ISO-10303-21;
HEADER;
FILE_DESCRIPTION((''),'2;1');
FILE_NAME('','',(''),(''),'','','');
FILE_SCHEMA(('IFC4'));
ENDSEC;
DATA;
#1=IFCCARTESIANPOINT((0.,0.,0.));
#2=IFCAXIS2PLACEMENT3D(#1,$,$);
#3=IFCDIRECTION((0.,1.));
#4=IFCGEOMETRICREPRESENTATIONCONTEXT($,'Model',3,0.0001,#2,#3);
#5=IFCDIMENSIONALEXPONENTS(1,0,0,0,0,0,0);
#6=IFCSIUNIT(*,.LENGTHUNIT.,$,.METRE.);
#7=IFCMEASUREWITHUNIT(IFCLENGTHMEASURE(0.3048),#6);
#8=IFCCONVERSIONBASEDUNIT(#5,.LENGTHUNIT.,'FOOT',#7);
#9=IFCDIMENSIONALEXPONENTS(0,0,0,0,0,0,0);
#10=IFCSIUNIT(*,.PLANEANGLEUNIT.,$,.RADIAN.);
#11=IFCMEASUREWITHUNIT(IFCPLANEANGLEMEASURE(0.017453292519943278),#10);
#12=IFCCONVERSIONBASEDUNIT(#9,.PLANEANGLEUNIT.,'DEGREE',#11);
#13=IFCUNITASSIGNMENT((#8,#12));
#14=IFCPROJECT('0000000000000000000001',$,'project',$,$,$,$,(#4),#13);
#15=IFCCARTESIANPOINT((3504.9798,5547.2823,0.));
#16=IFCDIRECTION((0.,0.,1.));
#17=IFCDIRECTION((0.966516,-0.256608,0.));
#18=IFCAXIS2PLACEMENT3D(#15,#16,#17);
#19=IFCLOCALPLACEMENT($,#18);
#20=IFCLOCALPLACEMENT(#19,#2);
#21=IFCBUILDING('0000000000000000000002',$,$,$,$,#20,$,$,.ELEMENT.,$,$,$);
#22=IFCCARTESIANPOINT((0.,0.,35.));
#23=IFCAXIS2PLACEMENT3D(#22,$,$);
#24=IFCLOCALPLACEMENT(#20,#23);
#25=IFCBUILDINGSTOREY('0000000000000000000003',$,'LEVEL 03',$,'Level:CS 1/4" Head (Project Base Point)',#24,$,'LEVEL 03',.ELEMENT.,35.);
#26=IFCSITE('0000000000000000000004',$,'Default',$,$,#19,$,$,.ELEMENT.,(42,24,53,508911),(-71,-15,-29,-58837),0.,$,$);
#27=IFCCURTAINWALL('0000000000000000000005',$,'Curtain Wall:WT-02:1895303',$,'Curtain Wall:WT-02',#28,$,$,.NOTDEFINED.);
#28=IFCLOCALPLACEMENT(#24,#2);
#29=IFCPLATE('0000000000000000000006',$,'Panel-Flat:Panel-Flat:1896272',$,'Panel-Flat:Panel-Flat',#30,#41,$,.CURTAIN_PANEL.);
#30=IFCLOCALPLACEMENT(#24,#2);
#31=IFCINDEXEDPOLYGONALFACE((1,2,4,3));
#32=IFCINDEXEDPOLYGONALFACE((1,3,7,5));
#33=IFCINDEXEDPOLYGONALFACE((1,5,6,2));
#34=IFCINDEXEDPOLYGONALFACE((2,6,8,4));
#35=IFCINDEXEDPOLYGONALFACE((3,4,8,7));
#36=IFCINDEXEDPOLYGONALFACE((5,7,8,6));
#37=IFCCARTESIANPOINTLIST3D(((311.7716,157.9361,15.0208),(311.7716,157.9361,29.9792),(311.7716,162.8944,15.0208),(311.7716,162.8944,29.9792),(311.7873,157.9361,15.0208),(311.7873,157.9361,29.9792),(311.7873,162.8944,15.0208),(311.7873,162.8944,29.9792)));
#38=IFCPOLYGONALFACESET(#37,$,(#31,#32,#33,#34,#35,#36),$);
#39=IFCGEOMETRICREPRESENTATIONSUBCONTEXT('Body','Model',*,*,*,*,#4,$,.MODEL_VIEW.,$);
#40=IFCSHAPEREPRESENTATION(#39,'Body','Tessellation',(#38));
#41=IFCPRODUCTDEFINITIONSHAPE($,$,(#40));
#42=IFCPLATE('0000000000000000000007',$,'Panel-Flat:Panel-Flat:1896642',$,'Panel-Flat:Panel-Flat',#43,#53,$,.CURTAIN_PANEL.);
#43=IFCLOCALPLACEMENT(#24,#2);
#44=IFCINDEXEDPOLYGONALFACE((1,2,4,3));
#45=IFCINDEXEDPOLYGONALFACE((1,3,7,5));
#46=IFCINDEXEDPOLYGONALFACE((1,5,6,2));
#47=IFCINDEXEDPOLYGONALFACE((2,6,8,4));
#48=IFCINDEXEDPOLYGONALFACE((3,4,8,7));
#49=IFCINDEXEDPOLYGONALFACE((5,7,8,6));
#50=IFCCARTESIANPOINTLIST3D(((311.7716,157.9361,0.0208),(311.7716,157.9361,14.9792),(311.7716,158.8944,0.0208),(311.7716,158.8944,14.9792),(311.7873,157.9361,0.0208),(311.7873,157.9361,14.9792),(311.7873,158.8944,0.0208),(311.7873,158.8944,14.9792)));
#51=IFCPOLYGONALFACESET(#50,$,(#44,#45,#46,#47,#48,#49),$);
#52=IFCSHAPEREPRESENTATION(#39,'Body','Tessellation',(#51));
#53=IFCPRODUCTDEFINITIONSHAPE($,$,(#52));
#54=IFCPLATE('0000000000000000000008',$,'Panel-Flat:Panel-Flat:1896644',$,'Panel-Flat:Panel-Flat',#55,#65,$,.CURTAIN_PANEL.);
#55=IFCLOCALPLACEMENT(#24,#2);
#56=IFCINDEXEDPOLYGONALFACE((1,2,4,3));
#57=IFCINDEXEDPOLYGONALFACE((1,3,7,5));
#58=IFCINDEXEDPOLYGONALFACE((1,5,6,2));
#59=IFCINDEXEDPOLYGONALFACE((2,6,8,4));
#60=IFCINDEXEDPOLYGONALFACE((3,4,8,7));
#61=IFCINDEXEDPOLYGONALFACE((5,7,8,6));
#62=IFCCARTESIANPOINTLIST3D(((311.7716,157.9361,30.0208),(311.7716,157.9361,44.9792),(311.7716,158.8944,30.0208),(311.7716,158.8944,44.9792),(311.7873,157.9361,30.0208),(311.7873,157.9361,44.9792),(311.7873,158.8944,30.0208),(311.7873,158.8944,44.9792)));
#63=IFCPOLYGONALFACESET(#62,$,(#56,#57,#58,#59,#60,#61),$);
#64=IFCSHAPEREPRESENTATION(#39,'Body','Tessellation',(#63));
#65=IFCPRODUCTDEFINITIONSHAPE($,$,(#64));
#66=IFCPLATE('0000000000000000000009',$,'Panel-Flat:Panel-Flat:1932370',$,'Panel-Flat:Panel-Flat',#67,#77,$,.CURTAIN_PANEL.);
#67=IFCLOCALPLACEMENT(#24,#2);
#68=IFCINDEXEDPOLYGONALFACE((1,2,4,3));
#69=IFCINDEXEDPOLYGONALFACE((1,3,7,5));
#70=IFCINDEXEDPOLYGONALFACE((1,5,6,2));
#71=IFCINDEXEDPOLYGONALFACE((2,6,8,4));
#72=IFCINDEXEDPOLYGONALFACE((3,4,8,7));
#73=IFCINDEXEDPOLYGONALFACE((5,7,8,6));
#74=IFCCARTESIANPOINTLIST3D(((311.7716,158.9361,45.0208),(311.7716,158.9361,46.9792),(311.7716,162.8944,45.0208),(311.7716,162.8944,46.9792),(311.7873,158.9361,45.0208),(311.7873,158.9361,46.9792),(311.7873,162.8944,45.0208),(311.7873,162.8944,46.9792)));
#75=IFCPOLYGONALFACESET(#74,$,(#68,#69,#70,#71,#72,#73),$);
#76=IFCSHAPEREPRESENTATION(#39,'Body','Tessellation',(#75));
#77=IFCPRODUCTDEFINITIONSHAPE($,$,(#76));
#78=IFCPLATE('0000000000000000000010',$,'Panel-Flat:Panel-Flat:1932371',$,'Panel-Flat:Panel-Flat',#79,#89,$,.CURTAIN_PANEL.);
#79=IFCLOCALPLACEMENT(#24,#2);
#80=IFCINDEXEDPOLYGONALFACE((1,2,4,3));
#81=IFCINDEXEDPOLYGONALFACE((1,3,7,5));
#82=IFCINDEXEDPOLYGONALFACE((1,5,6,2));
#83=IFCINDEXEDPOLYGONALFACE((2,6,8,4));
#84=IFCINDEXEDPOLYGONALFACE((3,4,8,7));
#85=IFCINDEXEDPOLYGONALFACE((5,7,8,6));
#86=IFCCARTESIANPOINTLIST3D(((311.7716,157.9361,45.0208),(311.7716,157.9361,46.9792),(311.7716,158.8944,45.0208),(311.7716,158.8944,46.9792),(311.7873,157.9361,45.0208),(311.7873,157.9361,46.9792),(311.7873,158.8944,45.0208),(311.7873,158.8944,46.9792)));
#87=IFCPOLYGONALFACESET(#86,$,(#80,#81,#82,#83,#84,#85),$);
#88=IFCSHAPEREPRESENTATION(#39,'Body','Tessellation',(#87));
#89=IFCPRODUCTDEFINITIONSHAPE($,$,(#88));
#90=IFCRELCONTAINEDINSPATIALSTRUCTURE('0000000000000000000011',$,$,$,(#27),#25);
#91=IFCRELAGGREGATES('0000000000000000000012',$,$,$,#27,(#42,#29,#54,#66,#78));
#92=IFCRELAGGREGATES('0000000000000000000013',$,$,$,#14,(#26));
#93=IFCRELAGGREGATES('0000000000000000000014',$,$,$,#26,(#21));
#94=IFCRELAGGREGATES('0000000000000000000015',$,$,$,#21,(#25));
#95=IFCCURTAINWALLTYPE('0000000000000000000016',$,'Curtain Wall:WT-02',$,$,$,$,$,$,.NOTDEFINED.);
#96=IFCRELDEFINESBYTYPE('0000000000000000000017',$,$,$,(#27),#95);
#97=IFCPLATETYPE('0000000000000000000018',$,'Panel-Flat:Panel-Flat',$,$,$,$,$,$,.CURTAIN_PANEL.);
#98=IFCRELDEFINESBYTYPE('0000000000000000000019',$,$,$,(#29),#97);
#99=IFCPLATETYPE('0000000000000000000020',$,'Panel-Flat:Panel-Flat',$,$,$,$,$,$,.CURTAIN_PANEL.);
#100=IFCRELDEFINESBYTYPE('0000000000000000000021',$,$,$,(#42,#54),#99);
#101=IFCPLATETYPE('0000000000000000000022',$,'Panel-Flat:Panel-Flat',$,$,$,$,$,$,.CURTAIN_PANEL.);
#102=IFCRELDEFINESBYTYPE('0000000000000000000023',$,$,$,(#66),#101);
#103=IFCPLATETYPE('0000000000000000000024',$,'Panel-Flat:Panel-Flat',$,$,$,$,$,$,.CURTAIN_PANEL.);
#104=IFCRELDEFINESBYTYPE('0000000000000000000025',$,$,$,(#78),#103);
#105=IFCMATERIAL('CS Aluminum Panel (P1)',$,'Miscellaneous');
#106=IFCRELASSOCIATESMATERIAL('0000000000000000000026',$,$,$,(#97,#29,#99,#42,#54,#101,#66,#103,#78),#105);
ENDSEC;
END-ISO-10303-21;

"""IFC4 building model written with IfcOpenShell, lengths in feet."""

from ifc_helpers import new_model, entity, si_unit, converted_unit, direction, frame, origin, place, context, subcontext, project, spatial, indexed_curve, outline, extrude, source, transform, mapped, material, type_object, type_shapes, element, aggregate, save


model = new_model("IFC4")

# Units and contexts
model_context = context("Model", 3, precision=0.0001, world=origin(), true_north=direction((0.0, 1.0)))
body_context = subcontext(model_context, "Body", "Model", "MODEL_VIEW")
ifc_project = project(units=[converted_unit("LENGTHUNIT", "FOOT", entity("IfcLengthMeasure", 0.3048), si_unit("LENGTHUNIT", "METRE"), dimensions=[1, 0, 0, 0, 0, 0, 0]), converted_unit("PLANEANGLEUNIT", "DEGREE", entity("IfcPlaneAngleMeasure", 0.017453292519943278), si_unit("PLANEANGLEUNIT", "RADIAN"), dimensions=[0, 0, 0, 0, 0, 0, 0])], contexts=[model_context])

# Site, building, storey
site_placement = place(None, frame((3504.9798, 5547.2823, 0.0), z_axis=(0.0, 0.0, 1.0), x_axis=(0.966516, -0.256608, 0.0)))
site = spatial("IfcSite", under=ifc_project, at=site_placement, Name="Default", CompositionType="ELEMENT", RefLatitude=(42, 24, 53, 508911), RefLongitude=(-71, -15, -29, -58837), RefElevation=0.0)
building_placement = place(site_placement, origin())
building = spatial("IfcBuilding", under=site, at=building_placement, CompositionType="ELEMENT")
storey_placement = place(building_placement, frame((0.0, 0.0, 35.0)))
storey = spatial("IfcBuildingStorey", under=building, at=storey_placement, Name="LEVEL 03", ObjectType="Level:CS 1/4\" Head (Project Base Point)", LongName="LEVEL 03", CompositionType="ELEMENT", Elevation=35.0)

# Curtain wall, plates
curtain_wall_type = type_object("IfcCurtainWallType", Name="Curtain Wall:WT-02", PredefinedType="NOTDEFINED")
curtain_wall_placement = place(storey_placement, frame((0.0, 0.0, -35.0)))
curtain_wall = element("IfcCurtainWall", 1, at=curtain_wall_placement, inside=storey, type_object=curtain_wall_type, Name="Curtain Wall:WT-02:1895303", ObjectType="Curtain Wall:WT-02", PredefinedType="NOTDEFINED")
ifc_material_1 = material(Name="CS Aluminum Panel (P1)", Category="Miscellaneous")
plate_type_1 = type_object("IfcPlateType", Name="Panel-Flat:Panel-Flat", PredefinedType="CURTAIN_PANEL", material=ifc_material_1)
shared_shape_1 = source(origin(), body_context, "Body", "SweptSolid", [
    extrude(outline(indexed_curve([(-0.0078, -2.4792), (0.0078, -2.4792), (0.0078, 2.4792), (-0.0078, 2.4792), (-0.0078, -2.4792)], self_intersect=False)), frame((2.4792, 0.0078, 0.0), z_axis=(0.0, 0.0, 1.0), x_axis=(0.0, -1.0, 0.0)), (0.0, 0.0, 1.0), 14.9583),
])
type_shapes(plate_type_1, [shared_shape_1])
plate_1_placement = place(curtain_wall_placement, frame((311.7716, 162.8944, 50.0208), z_axis=(0.0, 0.0, 1.0), x_axis=(0.0, -1.0, 0.0)))
plate_1 = element("IfcPlate", 2, at=plate_1_placement, type_object=plate_type_1, material=ifc_material_1, Name="Panel-Flat:Panel-Flat:1896272", ObjectType="Panel-Flat:Panel-Flat", PredefinedType="CURTAIN_PANEL", context=body_context, shape_type="MappedRepresentation", body=[
    mapped(shared_shape_1, transform((0.0, 0.0, 0.0), scale=1.0)),
])
plate_type_2 = type_object("IfcPlateType", Name="Panel-Flat:Panel-Flat", PredefinedType="CURTAIN_PANEL", material=ifc_material_1)
shared_shape_2 = source(origin(), body_context, "Body", "SweptSolid", [
    extrude(outline(indexed_curve([(-0.0078, -0.4792), (0.0078, -0.4792), (0.0078, 0.4792), (-0.0078, 0.4792), (-0.0078, -0.4792)], self_intersect=False)), frame((0.4792, 0.0078, 0.0), z_axis=(0.0, 0.0, 1.0), x_axis=(0.0, -1.0, 0.0)), (0.0, 0.0, 1.0), 14.9583),
])
type_shapes(plate_type_2, [shared_shape_2])
plate_2_placement = place(curtain_wall_placement, frame((311.7716, 158.8944, 35.0208), z_axis=(0.0, 0.0, 1.0), x_axis=(0.0, -1.0, 0.0)))
plate_2 = element("IfcPlate", 3, at=plate_2_placement, type_object=plate_type_2, material=ifc_material_1, Name="Panel-Flat:Panel-Flat:1896642", ObjectType="Panel-Flat:Panel-Flat", PredefinedType="CURTAIN_PANEL", context=body_context, shape_type="MappedRepresentation", body=[
    mapped(shared_shape_2, transform((0.0, 0.0, 0.0), scale=1.0)),
])
plate_3_placement = place(curtain_wall_placement, frame((311.7716, 158.8944, 65.0208), z_axis=(0.0, 0.0, 1.0), x_axis=(0.0, -1.0, 0.0)))
plate_3 = element("IfcPlate", 4, at=plate_3_placement, type_object=plate_type_2, material=ifc_material_1, Name="Panel-Flat:Panel-Flat:1896644", ObjectType="Panel-Flat:Panel-Flat", PredefinedType="CURTAIN_PANEL", context=body_context, shape_type="MappedRepresentation", body=[
    mapped(shared_shape_2, transform((0.0, 0.0, 0.0), scale=1.0)),
])
plate_type_3 = type_object("IfcPlateType", Name="Panel-Flat:Panel-Flat", PredefinedType="CURTAIN_PANEL", material=ifc_material_1)
shared_shape_3 = source(origin(), body_context, "Body", "SweptSolid", [
    extrude(outline(indexed_curve([(-0.0078, -1.9792), (0.0078, -1.9792), (0.0078, 1.9792), (-0.0078, 1.9792), (-0.0078, -1.9792)], self_intersect=False)), frame((1.9792, 0.0078, 0.0), z_axis=(0.0, 0.0, 1.0), x_axis=(0.0, -1.0, 0.0)), (0.0, 0.0, 1.0), 1.9583),
])
type_shapes(plate_type_3, [shared_shape_3])
plate_4_placement = place(curtain_wall_placement, frame((311.7716, 162.8944, 80.0208), z_axis=(0.0, 0.0, 1.0), x_axis=(0.0, -1.0, 0.0)))
plate_4 = element("IfcPlate", 5, at=plate_4_placement, type_object=plate_type_3, material=ifc_material_1, Name="Panel-Flat:Panel-Flat:1932370", ObjectType="Panel-Flat:Panel-Flat", PredefinedType="CURTAIN_PANEL", context=body_context, shape_type="MappedRepresentation", body=[
    mapped(shared_shape_3, transform((0.0, 0.0, 0.0), scale=1.0)),
])
plate_type_4 = type_object("IfcPlateType", Name="Panel-Flat:Panel-Flat", PredefinedType="CURTAIN_PANEL", material=ifc_material_1)
shared_shape_4 = source(origin(), body_context, "Body", "SweptSolid", [
    extrude(outline(indexed_curve([(-0.0078, -0.4792), (0.0078, -0.4792), (0.0078, 0.4792), (-0.0078, 0.4792), (-0.0078, -0.4792)], self_intersect=False)), frame((0.4792, 0.0078, 0.0), z_axis=(0.0, 0.0, 1.0), x_axis=(0.0, -1.0, 0.0)), (0.0, 0.0, 1.0), 1.9583),
])
type_shapes(plate_type_4, [shared_shape_4])
plate_5_placement = place(curtain_wall_placement, frame((311.7716, 158.8944, 80.0208), z_axis=(0.0, 0.0, 1.0), x_axis=(0.0, -1.0, 0.0)))
plate_5 = element("IfcPlate", 6, at=plate_5_placement, type_object=plate_type_4, material=ifc_material_1, Name="Panel-Flat:Panel-Flat:1932371", ObjectType="Panel-Flat:Panel-Flat", PredefinedType="CURTAIN_PANEL", context=body_context, shape_type="MappedRepresentation", body=[
    mapped(shared_shape_4, transform((0.0, 0.0, 0.0), scale=1.0)),
])
aggregate(curtain_wall, [plate_2, plate_1, plate_3, plate_4, plate_5])

save(model, "model.ifc")
